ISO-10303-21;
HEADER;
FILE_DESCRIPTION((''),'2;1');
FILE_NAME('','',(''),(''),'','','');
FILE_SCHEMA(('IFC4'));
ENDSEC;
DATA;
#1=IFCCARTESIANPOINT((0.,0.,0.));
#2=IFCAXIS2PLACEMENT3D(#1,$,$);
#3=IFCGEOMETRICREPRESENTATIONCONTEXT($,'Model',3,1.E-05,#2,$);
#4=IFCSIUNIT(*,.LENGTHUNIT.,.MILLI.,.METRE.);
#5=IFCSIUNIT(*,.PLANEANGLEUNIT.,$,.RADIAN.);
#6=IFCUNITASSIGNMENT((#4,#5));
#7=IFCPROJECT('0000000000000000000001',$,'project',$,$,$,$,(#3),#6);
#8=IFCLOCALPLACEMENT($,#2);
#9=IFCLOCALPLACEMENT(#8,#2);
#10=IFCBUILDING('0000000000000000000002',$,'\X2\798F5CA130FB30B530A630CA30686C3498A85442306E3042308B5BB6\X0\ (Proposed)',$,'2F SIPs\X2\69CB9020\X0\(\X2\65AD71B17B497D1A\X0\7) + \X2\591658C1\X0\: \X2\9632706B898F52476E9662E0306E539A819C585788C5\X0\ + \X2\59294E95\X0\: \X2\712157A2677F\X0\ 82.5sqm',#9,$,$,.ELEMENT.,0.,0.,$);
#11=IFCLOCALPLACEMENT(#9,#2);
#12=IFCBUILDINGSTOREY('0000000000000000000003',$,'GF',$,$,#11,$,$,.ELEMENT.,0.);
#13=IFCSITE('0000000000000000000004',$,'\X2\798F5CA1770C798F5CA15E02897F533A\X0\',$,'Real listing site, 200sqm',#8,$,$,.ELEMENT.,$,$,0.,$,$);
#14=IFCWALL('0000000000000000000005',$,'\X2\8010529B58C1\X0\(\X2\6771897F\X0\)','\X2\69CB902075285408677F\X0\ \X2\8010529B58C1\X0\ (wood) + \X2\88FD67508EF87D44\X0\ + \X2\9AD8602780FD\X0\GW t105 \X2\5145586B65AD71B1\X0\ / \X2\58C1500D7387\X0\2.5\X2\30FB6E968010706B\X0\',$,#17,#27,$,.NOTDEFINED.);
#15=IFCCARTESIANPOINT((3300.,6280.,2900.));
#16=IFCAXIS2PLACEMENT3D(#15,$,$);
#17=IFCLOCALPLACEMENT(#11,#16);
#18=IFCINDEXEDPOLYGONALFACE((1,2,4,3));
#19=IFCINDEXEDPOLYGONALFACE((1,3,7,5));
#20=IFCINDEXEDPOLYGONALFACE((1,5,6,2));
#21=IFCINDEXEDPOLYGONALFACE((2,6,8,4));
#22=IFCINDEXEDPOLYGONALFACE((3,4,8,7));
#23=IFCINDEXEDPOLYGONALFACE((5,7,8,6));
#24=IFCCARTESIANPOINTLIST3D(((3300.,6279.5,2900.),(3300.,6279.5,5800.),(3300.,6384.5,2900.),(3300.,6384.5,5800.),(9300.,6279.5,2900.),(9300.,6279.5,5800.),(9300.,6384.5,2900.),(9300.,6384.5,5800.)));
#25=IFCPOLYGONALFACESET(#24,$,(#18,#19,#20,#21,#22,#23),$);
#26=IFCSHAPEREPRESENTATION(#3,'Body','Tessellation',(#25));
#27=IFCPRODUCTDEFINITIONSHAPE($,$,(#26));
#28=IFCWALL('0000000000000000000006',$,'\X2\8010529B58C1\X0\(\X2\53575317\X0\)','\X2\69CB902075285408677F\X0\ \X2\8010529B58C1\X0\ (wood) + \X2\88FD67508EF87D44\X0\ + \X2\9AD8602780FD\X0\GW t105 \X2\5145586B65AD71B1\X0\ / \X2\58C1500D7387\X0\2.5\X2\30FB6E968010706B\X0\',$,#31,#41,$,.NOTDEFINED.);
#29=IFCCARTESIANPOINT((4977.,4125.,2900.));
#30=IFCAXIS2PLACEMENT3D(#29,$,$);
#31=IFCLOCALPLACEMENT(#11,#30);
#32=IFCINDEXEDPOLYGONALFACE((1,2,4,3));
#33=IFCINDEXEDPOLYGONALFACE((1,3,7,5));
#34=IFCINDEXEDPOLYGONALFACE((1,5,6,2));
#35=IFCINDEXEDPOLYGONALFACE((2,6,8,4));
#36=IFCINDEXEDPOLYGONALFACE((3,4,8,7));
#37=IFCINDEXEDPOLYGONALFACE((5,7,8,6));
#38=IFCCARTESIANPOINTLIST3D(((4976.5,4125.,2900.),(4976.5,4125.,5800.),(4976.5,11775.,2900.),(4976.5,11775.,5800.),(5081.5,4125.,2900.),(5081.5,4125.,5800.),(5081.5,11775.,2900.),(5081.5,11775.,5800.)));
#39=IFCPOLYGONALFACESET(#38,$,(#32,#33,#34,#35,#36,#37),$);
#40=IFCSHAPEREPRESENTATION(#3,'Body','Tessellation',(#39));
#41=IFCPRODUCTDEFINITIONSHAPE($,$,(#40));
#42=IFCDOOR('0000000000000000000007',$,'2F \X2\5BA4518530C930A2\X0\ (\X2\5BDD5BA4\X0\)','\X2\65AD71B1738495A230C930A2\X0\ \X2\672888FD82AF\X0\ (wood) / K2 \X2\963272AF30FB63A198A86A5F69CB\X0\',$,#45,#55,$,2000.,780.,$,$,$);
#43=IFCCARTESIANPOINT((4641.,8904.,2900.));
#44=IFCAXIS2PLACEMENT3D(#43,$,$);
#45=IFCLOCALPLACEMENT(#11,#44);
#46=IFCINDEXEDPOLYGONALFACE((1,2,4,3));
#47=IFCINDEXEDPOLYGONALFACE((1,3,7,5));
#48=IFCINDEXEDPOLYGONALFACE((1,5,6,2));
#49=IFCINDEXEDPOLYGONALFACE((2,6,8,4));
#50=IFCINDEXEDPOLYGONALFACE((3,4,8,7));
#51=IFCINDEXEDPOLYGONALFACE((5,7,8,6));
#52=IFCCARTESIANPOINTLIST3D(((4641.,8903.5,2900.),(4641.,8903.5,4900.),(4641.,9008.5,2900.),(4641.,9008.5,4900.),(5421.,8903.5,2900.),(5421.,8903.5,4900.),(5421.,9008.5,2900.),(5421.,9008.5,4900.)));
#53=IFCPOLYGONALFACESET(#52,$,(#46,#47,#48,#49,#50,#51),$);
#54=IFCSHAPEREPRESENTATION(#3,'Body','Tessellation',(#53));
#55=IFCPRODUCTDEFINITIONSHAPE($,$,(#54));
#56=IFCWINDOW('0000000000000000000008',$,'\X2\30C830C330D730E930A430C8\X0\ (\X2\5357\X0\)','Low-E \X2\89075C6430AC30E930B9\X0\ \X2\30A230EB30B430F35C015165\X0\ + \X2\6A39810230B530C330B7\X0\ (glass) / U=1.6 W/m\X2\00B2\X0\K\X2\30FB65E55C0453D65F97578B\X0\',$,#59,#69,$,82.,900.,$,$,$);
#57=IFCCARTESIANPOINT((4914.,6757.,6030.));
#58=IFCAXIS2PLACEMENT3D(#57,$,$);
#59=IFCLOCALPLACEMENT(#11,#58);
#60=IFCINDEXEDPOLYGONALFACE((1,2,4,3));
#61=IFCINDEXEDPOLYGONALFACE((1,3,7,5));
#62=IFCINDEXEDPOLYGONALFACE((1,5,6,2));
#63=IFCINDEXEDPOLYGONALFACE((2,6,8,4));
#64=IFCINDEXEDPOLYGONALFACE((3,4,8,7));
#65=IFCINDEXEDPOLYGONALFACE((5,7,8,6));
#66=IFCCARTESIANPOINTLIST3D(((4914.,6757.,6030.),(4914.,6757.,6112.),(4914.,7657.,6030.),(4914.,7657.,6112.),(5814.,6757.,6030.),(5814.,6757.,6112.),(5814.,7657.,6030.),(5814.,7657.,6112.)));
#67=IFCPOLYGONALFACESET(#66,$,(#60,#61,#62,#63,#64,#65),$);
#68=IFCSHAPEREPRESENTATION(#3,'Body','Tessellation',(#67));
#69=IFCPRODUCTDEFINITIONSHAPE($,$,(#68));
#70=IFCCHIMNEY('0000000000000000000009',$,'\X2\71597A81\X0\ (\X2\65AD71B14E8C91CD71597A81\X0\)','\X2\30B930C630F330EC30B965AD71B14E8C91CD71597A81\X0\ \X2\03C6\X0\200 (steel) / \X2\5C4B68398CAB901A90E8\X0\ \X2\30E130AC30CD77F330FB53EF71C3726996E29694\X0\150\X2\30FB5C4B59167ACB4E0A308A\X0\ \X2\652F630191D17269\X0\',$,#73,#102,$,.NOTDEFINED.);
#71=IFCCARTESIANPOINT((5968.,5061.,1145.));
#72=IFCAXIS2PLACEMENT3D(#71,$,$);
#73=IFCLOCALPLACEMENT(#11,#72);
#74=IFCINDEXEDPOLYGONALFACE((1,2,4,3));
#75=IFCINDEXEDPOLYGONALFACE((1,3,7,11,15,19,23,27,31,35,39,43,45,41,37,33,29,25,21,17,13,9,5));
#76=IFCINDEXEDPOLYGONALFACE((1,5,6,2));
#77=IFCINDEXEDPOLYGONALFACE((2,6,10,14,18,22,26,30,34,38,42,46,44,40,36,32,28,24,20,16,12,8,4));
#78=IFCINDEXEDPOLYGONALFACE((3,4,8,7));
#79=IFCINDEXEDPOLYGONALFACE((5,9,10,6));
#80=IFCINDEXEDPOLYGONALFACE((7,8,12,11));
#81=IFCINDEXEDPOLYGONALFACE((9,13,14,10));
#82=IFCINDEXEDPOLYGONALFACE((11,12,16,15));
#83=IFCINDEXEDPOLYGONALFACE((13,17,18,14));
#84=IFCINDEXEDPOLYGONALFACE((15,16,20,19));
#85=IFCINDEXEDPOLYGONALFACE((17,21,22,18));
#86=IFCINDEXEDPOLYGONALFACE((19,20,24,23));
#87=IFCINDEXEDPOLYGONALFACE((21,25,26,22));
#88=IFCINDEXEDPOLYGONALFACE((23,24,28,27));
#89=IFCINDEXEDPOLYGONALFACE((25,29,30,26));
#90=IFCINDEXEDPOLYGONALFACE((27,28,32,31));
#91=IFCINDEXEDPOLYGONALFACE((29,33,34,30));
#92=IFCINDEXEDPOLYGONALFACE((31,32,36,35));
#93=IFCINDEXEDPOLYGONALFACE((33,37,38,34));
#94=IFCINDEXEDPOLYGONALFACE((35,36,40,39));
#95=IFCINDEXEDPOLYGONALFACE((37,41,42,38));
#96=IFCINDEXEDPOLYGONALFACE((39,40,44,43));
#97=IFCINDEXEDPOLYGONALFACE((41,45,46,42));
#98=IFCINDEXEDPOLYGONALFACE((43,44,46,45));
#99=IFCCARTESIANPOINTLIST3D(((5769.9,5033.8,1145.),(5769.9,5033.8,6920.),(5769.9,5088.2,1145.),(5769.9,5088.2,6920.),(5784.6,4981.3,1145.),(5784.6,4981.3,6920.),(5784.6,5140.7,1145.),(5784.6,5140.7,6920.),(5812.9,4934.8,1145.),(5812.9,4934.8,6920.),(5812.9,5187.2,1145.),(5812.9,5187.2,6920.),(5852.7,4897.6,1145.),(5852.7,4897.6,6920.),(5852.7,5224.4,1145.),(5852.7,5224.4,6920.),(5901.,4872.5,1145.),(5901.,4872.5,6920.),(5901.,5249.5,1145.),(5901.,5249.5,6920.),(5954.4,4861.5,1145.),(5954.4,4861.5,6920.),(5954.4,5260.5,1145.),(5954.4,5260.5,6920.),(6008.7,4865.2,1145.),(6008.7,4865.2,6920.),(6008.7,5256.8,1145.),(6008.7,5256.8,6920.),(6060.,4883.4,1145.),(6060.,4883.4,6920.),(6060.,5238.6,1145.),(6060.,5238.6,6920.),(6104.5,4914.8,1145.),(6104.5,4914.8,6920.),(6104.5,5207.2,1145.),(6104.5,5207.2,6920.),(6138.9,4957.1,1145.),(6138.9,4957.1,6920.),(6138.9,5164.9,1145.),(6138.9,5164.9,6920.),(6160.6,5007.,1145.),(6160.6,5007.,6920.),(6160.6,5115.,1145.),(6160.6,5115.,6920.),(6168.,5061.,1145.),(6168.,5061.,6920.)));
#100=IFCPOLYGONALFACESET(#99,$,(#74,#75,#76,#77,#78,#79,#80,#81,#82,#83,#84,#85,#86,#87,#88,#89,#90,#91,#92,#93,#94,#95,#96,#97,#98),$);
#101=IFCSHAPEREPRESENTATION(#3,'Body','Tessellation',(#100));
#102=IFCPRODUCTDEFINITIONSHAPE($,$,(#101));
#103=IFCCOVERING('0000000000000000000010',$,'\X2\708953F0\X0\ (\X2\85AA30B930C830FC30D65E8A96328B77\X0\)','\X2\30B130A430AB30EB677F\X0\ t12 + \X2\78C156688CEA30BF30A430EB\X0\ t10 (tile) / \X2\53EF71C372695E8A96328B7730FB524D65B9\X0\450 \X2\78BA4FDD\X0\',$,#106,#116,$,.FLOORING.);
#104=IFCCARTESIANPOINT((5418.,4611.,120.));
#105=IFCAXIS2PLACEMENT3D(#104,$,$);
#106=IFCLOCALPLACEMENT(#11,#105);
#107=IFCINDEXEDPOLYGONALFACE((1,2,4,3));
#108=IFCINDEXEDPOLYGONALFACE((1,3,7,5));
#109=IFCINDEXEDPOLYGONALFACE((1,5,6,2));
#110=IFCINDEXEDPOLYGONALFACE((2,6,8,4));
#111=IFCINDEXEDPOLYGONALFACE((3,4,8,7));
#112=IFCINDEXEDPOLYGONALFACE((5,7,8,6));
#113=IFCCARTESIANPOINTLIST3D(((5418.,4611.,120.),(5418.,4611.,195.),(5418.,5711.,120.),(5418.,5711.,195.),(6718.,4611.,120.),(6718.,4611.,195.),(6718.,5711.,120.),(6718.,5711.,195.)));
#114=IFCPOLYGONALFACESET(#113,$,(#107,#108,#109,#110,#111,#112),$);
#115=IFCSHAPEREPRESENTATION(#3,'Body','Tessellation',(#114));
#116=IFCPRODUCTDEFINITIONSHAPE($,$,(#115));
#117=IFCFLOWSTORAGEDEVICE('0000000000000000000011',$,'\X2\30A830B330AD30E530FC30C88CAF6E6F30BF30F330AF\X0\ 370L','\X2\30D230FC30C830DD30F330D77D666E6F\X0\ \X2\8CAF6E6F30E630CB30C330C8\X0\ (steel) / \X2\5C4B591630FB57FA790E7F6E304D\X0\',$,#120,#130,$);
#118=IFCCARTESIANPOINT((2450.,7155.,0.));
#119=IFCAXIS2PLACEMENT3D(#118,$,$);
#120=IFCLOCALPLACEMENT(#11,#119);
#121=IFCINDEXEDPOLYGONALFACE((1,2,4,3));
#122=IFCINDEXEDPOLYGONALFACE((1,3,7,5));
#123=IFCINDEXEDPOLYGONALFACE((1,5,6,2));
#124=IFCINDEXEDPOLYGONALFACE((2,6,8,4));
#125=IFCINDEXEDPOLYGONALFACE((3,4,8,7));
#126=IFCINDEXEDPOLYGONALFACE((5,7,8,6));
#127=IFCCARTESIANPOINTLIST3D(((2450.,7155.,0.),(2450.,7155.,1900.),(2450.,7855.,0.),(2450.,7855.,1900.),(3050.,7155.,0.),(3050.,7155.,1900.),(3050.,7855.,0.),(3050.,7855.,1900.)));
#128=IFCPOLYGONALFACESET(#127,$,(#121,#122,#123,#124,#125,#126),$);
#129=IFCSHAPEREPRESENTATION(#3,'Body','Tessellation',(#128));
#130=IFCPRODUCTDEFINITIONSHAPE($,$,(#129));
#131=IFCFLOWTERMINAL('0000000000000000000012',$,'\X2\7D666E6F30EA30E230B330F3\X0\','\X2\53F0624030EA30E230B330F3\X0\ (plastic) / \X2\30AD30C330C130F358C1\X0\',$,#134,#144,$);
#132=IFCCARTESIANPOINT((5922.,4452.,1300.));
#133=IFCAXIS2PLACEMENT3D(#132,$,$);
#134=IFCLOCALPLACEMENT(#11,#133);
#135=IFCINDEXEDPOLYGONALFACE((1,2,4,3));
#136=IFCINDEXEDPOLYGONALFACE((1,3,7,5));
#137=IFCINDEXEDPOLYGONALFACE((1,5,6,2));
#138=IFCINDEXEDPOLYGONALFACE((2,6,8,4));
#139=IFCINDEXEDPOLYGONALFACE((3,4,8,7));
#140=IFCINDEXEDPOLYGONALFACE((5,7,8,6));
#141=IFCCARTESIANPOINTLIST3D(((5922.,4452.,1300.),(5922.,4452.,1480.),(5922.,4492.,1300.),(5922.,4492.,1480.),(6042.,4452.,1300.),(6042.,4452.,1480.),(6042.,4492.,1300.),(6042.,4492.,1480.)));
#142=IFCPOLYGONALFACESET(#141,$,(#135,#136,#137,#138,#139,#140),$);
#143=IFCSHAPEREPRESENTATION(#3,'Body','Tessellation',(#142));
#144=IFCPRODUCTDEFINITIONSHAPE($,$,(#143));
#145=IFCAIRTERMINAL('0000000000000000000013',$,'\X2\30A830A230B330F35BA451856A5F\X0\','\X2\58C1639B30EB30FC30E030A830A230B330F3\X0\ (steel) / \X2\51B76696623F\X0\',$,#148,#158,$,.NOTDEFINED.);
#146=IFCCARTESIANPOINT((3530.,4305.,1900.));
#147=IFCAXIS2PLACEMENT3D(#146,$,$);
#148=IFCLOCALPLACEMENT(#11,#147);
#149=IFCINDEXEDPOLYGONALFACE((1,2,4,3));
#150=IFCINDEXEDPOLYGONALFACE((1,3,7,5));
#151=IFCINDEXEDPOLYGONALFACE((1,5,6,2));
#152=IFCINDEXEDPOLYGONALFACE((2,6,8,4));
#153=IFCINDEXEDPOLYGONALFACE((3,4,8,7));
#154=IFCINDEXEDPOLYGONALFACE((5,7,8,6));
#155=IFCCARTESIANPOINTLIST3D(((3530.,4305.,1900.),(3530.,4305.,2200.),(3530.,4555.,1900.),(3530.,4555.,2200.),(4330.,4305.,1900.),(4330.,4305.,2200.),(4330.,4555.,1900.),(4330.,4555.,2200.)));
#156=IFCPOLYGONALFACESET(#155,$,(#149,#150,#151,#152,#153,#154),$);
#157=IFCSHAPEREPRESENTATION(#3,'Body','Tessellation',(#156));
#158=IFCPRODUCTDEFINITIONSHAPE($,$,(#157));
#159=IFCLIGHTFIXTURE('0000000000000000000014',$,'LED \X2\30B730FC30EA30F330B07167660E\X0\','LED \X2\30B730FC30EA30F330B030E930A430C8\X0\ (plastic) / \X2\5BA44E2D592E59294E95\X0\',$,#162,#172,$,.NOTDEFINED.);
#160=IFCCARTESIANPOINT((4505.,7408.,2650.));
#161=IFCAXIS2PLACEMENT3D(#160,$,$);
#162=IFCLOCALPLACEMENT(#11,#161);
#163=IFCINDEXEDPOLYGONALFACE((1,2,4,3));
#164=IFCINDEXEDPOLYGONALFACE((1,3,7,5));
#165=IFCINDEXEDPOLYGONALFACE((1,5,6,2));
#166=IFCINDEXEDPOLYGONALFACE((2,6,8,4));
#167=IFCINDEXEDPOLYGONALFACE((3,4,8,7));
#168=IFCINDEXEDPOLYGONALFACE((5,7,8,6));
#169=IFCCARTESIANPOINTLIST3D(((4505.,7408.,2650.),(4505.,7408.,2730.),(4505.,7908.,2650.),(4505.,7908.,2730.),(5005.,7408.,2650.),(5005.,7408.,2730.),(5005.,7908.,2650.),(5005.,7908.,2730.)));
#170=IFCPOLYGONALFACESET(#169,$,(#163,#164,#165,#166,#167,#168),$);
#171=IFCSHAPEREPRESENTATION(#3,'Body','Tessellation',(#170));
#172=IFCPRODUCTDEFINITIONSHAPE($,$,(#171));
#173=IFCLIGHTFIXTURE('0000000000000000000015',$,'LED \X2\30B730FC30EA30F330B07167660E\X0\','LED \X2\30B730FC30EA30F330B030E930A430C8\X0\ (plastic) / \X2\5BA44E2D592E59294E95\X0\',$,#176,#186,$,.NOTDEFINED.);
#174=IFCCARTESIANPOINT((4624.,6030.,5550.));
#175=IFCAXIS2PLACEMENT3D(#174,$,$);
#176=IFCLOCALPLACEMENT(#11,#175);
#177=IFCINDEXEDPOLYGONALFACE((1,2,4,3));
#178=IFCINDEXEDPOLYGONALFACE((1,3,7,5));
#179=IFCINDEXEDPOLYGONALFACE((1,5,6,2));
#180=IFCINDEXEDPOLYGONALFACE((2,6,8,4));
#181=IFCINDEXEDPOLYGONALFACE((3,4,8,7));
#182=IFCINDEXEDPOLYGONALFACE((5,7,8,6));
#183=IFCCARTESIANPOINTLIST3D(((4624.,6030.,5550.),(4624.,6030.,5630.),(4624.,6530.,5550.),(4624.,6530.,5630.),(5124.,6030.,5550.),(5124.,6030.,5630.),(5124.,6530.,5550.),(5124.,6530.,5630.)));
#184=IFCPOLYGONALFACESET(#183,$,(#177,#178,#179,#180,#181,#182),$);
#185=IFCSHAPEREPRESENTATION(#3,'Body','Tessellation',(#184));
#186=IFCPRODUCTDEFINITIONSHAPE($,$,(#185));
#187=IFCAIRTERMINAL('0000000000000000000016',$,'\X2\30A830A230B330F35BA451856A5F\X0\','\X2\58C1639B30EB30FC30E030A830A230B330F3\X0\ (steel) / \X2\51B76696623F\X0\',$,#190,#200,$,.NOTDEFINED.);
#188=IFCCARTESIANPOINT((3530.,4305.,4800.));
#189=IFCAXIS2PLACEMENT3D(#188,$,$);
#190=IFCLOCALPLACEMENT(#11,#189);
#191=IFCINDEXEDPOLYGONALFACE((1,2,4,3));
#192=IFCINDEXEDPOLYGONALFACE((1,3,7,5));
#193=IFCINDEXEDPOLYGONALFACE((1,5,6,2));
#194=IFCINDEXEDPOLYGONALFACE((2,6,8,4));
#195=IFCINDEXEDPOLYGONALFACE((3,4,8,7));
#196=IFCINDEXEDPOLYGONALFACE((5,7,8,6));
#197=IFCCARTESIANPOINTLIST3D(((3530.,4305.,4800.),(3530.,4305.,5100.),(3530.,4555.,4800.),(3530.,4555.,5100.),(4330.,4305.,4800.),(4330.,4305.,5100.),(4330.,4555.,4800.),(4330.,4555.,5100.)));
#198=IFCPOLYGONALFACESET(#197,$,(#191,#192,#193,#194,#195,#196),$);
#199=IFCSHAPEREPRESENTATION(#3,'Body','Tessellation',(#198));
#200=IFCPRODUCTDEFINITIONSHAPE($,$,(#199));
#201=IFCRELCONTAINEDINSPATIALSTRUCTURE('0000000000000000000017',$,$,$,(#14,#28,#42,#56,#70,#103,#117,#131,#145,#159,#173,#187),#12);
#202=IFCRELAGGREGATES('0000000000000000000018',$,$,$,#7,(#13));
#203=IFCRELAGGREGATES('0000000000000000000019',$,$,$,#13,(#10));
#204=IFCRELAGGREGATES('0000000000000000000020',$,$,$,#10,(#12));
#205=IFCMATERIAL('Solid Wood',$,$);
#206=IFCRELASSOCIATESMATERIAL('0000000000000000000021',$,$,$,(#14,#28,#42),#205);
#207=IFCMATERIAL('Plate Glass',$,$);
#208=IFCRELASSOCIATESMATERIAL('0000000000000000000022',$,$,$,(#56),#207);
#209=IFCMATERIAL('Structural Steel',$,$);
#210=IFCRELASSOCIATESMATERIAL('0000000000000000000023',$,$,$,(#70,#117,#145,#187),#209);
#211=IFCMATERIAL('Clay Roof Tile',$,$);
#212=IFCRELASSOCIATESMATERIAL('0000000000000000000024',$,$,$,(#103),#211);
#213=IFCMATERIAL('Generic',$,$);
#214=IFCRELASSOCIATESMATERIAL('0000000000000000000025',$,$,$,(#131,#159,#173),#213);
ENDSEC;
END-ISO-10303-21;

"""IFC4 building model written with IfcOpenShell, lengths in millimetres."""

from ifc_helpers import new_model, si_unit, frame, frame_2d, origin, origin_2d, place, context, project, spatial, rectangle, circle, extrude, material, element, fill, save


model = new_model("IFC4")

# Units and contexts
model_context = context("Model", 3, precision=1e-05, world=origin())
ifc_project = project(units=[si_unit("LENGTHUNIT", "METRE", prefix="MILLI"), si_unit("PLANEANGLEUNIT", "RADIAN")], contexts=[model_context])

# Site, building, storey
site_placement = place(None, origin())
site = spatial("IfcSite", under=ifc_project, at=site_placement, Name="福岡県福岡市西区", ObjectType="Real listing site, 200sqm", CompositionType="ELEMENT", RefElevation=0.0)
building_placement = place(site_placement, origin())
building = spatial("IfcBuilding", under=site, at=building_placement, Name="福岡・サウナと水風呂のある家 (Proposed)", ObjectType="2F SIPs構造(断熱等級7) + 外壁: 防火規則準拠の厚膜塗装 + 天井: 無垢板 82.5sqm", CompositionType="ELEMENT", ElevationOfRefHeight=0.0, ElevationOfTerrain=0.0)
storey_placement = place(building_placement, origin())
storey = spatial("IfcBuildingStorey", under=building, at=storey_placement, Name="GF", CompositionType="ELEMENT", Elevation=0.0)

# Shared definitions
ifc_material_1 = material(Name="Solid Wood")

# Wall
wall_1_placement = place(storey_placement, frame((3300.0, 6280.0, 2900.0)))
element("IfcWall", 1, at=wall_1_placement, inside=storey, material=ifc_material_1, Name="耐力壁(東西)", Description="構造用合板 耐力壁 (wood) + 製材軸組 + 高性能GW t105 充填断熱 / 壁倍率2.5・準耐火", PredefinedType="NOTDEFINED", context=model_context, shape_type="SweptSolid", body=[
    extrude(rectangle(XDim=6000.0, YDim=105.0, at=frame_2d((3000.0, 52.0))), frame((3300.0, 6280.0, 2900.0)), (0.0, 0.0, 1.0), 2900.0),
])

# Wall, opening, door
wall_2_placement = place(storey_placement, frame((4977.0, 4125.0, 2900.0)))
wall_2 = element("IfcWall", 2, at=wall_2_placement, inside=storey, material=ifc_material_1, Name="耐力壁(南北)", Description="構造用合板 耐力壁 (wood) + 製材軸組 + 高性能GW t105 充填断熱 / 壁倍率2.5・準耐火", PredefinedType="NOTDEFINED", context=model_context, shape_type="SweptSolid", body=[
    extrude(rectangle(XDim=105.0, YDim=7650.0, at=frame_2d((52.0, 3825.0))), frame((4977.0, 4125.0, 2900.0)), (0.0, 0.0, 1.0), 2900.0),
])
opening_placement = place(storey_placement, frame((4641.0, 8904.0, 2900.0)))
opening = element("IfcOpeningElement", 3, at=opening_placement, cuts=wall_2, PredefinedType="NOTDEFINED", context=model_context, shape_type="SweptSolid", body=[
    extrude(rectangle(XDim=780.0, YDim=105.0, at=frame_2d((390.0, 52.0))), frame((4641.0, 8904.0, 2900.0)), (0.0, 0.0, 1.0), 2000.0),
])
door_placement = place(storey_placement, frame((4641.0, 8904.0, 2900.0)))
door = element("IfcDoor", 4, at=door_placement, inside=storey, material=ifc_material_1, Name="2F 室内ドア (寝室)", Description="断熱玄関ドア 木製芯 (wood) / K2 防犯・採風機構", OverallHeight=2000.0, OverallWidth=780.0, context=model_context, shape_type="SweptSolid", body=[
    extrude(rectangle(XDim=780.0, YDim=105.0, at=frame_2d((390.0, 52.0))), frame((4641.0, 8904.0, 2900.0)), (0.0, 0.0, 1.0), 2000.0),
])
fill(opening, door)

# Window
ifc_material_2 = material(Name="Plate Glass")
window_placement = place(storey_placement, frame((4914.0, 6757.0, 6030.0)))
element("IfcWindow", 5, at=window_placement, inside=storey, material=ifc_material_2, Name="トップライト (南)", Description="Low-E 複層ガラス アルゴン封入 + 樹脂サッシ (glass) / U=1.6 W/m²K・日射取得型", OverallHeight=82.0, OverallWidth=900.0, context=model_context, shape_type="SweptSolid", body=[
    extrude(rectangle(XDim=900.0, YDim=900.0, at=frame_2d((450.0, 450.0))), frame((4914.0, 6757.0, 6030.0)), (0.0, 0.0, 1.0), 82.0),
])

# Chimney
ifc_material_3 = material(Name="Structural Steel")
chimney_placement = place(storey_placement, frame((5968.0, 5061.0, 1145.0)))
element("IfcChimney", 6, at=chimney_placement, inside=storey, material=ifc_material_3, Name="煙突 (断熱二重煙突)", Description="ステンレス断熱二重煙突 φ200 (steel) / 屋根貫通部 メガネ石・可燃物離隔150・屋外立上り 支持金物", PredefinedType="NOTDEFINED", context=model_context, shape_type="SweptSolid", body=[
    extrude(circle(Radius=200.0, at=origin_2d()), frame((5968.0, 5061.0, 1145.0)), (0.0, 0.0, 1.0), 5775.0),
])

# Covering
ifc_material_4 = material(Name="Clay Roof Tile")
covering_placement = place(storey_placement, frame((5418.0, 4611.0, 120.0)))
element("IfcCovering", 7, at=covering_placement, inside=storey, material=ifc_material_4, Name="炉台 (薪ストーブ床防護)", Description="ケイカル板 t12 + 磁器質タイル t10 (tile) / 可燃物床防護・前方450 確保", PredefinedType="FLOORING", context=model_context, shape_type="SweptSolid", body=[
    extrude(rectangle(XDim=1300.0, YDim=1100.0, at=frame_2d((650.0, 550.0))), frame((5418.0, 4611.0, 120.0)), (0.0, 0.0, 1.0), 75.0),
])

# Flow storage device
flow_storage_device_placement = place(storey_placement, frame((2450.0, 7155.0, 0.0)))
element("IfcFlowStorageDevice", 8, at=flow_storage_device_placement, inside=storey, material=ifc_material_3, Name="エコキュート貯湯タンク 370L", Description="ヒートポンプ給湯 貯湯ユニット (steel) / 屋外・基礎置き", context=model_context, shape_type="SweptSolid", body=[
    extrude(rectangle(XDim=600.0, YDim=700.0, at=frame_2d((300.0, 350.0))), frame((2450.0, 7155.0, 0.0)), (0.0, 0.0, 1.0), 1900.0),
])

# Flow terminal
ifc_material_5 = material(Name="Generic")
flow_terminal_1_placement = place(storey_placement, frame((5922.0, 4452.0, 1300.0)))
element("IfcFlowTerminal", 9, at=flow_terminal_1_placement, inside=storey, material=ifc_material_5, Name="給湯リモコン", Description="台所リモコン (plastic) / キッチン壁", context=model_context, shape_type="SweptSolid", body=[
    extrude(rectangle(XDim=120.0, YDim=40.0, at=frame_2d((60.0, 20.0))), frame((5922.0, 4452.0, 1300.0)), (0.0, 0.0, 1.0), 180.0),
])

# Air terminal
air_terminal_1_placement = place(storey_placement, frame((3530.0, 4305.0, 1900.0)))
element("IfcAirTerminal", 10, at=air_terminal_1_placement, inside=storey, material=ifc_material_3, Name="エアコン室内機", Description="壁掛ルームエアコン (steel) / 冷暖房", PredefinedType="NOTDEFINED", context=model_context, shape_type="SweptSolid", body=[
    extrude(rectangle(XDim=800.0, YDim=250.0, at=frame_2d((400.0, 125.0))), frame((3530.0, 4305.0, 1900.0)), (0.0, 0.0, 1.0), 300.0),
])

# Light fixtures
light_fixture_1_placement = place(storey_placement, frame((4505.0, 7408.0, 2650.0)))
element("IfcLightFixture", 11, at=light_fixture_1_placement, inside=storey, material=ifc_material_5, Name="LED シーリング照明", Description="LED シーリングライト (plastic) / 室中央天井", PredefinedType="NOTDEFINED", context=model_context, shape_type="SweptSolid", body=[
    extrude(rectangle(XDim=500.0, YDim=500.0, at=frame_2d((250.0, 250.0))), frame((4505.0, 7408.0, 2650.0)), (0.0, 0.0, 1.0), 80.0),
])
light_fixture_2_placement = place(storey_placement, frame((4624.0, 6030.0, 5550.0)))
element("IfcLightFixture", 12, at=light_fixture_2_placement, inside=storey, material=ifc_material_5, Name="LED シーリング照明", Description="LED シーリングライト (plastic) / 室中央天井", PredefinedType="NOTDEFINED", context=model_context, shape_type="SweptSolid", body=[
    extrude(rectangle(XDim=500.0, YDim=500.0, at=frame_2d((250.0, 250.0))), frame((4624.0, 6030.0, 5550.0)), (0.0, 0.0, 1.0), 80.0),
])

# Air terminal
air_terminal_2_placement = place(storey_placement, frame((3530.0, 4305.0, 4800.0)))
element("IfcAirTerminal", 13, at=air_terminal_2_placement, inside=storey, material=ifc_material_3, Name="エアコン室内機", Description="壁掛ルームエアコン (steel) / 冷暖房", PredefinedType="NOTDEFINED", context=model_context, shape_type="SweptSolid", body=[
    extrude(rectangle(XDim=800.0, YDim=250.0, at=frame_2d((400.0, 125.0))), frame((3530.0, 4305.0, 4800.0)), (0.0, 0.0, 1.0), 300.0),
])

save(model, "model.ifc")
